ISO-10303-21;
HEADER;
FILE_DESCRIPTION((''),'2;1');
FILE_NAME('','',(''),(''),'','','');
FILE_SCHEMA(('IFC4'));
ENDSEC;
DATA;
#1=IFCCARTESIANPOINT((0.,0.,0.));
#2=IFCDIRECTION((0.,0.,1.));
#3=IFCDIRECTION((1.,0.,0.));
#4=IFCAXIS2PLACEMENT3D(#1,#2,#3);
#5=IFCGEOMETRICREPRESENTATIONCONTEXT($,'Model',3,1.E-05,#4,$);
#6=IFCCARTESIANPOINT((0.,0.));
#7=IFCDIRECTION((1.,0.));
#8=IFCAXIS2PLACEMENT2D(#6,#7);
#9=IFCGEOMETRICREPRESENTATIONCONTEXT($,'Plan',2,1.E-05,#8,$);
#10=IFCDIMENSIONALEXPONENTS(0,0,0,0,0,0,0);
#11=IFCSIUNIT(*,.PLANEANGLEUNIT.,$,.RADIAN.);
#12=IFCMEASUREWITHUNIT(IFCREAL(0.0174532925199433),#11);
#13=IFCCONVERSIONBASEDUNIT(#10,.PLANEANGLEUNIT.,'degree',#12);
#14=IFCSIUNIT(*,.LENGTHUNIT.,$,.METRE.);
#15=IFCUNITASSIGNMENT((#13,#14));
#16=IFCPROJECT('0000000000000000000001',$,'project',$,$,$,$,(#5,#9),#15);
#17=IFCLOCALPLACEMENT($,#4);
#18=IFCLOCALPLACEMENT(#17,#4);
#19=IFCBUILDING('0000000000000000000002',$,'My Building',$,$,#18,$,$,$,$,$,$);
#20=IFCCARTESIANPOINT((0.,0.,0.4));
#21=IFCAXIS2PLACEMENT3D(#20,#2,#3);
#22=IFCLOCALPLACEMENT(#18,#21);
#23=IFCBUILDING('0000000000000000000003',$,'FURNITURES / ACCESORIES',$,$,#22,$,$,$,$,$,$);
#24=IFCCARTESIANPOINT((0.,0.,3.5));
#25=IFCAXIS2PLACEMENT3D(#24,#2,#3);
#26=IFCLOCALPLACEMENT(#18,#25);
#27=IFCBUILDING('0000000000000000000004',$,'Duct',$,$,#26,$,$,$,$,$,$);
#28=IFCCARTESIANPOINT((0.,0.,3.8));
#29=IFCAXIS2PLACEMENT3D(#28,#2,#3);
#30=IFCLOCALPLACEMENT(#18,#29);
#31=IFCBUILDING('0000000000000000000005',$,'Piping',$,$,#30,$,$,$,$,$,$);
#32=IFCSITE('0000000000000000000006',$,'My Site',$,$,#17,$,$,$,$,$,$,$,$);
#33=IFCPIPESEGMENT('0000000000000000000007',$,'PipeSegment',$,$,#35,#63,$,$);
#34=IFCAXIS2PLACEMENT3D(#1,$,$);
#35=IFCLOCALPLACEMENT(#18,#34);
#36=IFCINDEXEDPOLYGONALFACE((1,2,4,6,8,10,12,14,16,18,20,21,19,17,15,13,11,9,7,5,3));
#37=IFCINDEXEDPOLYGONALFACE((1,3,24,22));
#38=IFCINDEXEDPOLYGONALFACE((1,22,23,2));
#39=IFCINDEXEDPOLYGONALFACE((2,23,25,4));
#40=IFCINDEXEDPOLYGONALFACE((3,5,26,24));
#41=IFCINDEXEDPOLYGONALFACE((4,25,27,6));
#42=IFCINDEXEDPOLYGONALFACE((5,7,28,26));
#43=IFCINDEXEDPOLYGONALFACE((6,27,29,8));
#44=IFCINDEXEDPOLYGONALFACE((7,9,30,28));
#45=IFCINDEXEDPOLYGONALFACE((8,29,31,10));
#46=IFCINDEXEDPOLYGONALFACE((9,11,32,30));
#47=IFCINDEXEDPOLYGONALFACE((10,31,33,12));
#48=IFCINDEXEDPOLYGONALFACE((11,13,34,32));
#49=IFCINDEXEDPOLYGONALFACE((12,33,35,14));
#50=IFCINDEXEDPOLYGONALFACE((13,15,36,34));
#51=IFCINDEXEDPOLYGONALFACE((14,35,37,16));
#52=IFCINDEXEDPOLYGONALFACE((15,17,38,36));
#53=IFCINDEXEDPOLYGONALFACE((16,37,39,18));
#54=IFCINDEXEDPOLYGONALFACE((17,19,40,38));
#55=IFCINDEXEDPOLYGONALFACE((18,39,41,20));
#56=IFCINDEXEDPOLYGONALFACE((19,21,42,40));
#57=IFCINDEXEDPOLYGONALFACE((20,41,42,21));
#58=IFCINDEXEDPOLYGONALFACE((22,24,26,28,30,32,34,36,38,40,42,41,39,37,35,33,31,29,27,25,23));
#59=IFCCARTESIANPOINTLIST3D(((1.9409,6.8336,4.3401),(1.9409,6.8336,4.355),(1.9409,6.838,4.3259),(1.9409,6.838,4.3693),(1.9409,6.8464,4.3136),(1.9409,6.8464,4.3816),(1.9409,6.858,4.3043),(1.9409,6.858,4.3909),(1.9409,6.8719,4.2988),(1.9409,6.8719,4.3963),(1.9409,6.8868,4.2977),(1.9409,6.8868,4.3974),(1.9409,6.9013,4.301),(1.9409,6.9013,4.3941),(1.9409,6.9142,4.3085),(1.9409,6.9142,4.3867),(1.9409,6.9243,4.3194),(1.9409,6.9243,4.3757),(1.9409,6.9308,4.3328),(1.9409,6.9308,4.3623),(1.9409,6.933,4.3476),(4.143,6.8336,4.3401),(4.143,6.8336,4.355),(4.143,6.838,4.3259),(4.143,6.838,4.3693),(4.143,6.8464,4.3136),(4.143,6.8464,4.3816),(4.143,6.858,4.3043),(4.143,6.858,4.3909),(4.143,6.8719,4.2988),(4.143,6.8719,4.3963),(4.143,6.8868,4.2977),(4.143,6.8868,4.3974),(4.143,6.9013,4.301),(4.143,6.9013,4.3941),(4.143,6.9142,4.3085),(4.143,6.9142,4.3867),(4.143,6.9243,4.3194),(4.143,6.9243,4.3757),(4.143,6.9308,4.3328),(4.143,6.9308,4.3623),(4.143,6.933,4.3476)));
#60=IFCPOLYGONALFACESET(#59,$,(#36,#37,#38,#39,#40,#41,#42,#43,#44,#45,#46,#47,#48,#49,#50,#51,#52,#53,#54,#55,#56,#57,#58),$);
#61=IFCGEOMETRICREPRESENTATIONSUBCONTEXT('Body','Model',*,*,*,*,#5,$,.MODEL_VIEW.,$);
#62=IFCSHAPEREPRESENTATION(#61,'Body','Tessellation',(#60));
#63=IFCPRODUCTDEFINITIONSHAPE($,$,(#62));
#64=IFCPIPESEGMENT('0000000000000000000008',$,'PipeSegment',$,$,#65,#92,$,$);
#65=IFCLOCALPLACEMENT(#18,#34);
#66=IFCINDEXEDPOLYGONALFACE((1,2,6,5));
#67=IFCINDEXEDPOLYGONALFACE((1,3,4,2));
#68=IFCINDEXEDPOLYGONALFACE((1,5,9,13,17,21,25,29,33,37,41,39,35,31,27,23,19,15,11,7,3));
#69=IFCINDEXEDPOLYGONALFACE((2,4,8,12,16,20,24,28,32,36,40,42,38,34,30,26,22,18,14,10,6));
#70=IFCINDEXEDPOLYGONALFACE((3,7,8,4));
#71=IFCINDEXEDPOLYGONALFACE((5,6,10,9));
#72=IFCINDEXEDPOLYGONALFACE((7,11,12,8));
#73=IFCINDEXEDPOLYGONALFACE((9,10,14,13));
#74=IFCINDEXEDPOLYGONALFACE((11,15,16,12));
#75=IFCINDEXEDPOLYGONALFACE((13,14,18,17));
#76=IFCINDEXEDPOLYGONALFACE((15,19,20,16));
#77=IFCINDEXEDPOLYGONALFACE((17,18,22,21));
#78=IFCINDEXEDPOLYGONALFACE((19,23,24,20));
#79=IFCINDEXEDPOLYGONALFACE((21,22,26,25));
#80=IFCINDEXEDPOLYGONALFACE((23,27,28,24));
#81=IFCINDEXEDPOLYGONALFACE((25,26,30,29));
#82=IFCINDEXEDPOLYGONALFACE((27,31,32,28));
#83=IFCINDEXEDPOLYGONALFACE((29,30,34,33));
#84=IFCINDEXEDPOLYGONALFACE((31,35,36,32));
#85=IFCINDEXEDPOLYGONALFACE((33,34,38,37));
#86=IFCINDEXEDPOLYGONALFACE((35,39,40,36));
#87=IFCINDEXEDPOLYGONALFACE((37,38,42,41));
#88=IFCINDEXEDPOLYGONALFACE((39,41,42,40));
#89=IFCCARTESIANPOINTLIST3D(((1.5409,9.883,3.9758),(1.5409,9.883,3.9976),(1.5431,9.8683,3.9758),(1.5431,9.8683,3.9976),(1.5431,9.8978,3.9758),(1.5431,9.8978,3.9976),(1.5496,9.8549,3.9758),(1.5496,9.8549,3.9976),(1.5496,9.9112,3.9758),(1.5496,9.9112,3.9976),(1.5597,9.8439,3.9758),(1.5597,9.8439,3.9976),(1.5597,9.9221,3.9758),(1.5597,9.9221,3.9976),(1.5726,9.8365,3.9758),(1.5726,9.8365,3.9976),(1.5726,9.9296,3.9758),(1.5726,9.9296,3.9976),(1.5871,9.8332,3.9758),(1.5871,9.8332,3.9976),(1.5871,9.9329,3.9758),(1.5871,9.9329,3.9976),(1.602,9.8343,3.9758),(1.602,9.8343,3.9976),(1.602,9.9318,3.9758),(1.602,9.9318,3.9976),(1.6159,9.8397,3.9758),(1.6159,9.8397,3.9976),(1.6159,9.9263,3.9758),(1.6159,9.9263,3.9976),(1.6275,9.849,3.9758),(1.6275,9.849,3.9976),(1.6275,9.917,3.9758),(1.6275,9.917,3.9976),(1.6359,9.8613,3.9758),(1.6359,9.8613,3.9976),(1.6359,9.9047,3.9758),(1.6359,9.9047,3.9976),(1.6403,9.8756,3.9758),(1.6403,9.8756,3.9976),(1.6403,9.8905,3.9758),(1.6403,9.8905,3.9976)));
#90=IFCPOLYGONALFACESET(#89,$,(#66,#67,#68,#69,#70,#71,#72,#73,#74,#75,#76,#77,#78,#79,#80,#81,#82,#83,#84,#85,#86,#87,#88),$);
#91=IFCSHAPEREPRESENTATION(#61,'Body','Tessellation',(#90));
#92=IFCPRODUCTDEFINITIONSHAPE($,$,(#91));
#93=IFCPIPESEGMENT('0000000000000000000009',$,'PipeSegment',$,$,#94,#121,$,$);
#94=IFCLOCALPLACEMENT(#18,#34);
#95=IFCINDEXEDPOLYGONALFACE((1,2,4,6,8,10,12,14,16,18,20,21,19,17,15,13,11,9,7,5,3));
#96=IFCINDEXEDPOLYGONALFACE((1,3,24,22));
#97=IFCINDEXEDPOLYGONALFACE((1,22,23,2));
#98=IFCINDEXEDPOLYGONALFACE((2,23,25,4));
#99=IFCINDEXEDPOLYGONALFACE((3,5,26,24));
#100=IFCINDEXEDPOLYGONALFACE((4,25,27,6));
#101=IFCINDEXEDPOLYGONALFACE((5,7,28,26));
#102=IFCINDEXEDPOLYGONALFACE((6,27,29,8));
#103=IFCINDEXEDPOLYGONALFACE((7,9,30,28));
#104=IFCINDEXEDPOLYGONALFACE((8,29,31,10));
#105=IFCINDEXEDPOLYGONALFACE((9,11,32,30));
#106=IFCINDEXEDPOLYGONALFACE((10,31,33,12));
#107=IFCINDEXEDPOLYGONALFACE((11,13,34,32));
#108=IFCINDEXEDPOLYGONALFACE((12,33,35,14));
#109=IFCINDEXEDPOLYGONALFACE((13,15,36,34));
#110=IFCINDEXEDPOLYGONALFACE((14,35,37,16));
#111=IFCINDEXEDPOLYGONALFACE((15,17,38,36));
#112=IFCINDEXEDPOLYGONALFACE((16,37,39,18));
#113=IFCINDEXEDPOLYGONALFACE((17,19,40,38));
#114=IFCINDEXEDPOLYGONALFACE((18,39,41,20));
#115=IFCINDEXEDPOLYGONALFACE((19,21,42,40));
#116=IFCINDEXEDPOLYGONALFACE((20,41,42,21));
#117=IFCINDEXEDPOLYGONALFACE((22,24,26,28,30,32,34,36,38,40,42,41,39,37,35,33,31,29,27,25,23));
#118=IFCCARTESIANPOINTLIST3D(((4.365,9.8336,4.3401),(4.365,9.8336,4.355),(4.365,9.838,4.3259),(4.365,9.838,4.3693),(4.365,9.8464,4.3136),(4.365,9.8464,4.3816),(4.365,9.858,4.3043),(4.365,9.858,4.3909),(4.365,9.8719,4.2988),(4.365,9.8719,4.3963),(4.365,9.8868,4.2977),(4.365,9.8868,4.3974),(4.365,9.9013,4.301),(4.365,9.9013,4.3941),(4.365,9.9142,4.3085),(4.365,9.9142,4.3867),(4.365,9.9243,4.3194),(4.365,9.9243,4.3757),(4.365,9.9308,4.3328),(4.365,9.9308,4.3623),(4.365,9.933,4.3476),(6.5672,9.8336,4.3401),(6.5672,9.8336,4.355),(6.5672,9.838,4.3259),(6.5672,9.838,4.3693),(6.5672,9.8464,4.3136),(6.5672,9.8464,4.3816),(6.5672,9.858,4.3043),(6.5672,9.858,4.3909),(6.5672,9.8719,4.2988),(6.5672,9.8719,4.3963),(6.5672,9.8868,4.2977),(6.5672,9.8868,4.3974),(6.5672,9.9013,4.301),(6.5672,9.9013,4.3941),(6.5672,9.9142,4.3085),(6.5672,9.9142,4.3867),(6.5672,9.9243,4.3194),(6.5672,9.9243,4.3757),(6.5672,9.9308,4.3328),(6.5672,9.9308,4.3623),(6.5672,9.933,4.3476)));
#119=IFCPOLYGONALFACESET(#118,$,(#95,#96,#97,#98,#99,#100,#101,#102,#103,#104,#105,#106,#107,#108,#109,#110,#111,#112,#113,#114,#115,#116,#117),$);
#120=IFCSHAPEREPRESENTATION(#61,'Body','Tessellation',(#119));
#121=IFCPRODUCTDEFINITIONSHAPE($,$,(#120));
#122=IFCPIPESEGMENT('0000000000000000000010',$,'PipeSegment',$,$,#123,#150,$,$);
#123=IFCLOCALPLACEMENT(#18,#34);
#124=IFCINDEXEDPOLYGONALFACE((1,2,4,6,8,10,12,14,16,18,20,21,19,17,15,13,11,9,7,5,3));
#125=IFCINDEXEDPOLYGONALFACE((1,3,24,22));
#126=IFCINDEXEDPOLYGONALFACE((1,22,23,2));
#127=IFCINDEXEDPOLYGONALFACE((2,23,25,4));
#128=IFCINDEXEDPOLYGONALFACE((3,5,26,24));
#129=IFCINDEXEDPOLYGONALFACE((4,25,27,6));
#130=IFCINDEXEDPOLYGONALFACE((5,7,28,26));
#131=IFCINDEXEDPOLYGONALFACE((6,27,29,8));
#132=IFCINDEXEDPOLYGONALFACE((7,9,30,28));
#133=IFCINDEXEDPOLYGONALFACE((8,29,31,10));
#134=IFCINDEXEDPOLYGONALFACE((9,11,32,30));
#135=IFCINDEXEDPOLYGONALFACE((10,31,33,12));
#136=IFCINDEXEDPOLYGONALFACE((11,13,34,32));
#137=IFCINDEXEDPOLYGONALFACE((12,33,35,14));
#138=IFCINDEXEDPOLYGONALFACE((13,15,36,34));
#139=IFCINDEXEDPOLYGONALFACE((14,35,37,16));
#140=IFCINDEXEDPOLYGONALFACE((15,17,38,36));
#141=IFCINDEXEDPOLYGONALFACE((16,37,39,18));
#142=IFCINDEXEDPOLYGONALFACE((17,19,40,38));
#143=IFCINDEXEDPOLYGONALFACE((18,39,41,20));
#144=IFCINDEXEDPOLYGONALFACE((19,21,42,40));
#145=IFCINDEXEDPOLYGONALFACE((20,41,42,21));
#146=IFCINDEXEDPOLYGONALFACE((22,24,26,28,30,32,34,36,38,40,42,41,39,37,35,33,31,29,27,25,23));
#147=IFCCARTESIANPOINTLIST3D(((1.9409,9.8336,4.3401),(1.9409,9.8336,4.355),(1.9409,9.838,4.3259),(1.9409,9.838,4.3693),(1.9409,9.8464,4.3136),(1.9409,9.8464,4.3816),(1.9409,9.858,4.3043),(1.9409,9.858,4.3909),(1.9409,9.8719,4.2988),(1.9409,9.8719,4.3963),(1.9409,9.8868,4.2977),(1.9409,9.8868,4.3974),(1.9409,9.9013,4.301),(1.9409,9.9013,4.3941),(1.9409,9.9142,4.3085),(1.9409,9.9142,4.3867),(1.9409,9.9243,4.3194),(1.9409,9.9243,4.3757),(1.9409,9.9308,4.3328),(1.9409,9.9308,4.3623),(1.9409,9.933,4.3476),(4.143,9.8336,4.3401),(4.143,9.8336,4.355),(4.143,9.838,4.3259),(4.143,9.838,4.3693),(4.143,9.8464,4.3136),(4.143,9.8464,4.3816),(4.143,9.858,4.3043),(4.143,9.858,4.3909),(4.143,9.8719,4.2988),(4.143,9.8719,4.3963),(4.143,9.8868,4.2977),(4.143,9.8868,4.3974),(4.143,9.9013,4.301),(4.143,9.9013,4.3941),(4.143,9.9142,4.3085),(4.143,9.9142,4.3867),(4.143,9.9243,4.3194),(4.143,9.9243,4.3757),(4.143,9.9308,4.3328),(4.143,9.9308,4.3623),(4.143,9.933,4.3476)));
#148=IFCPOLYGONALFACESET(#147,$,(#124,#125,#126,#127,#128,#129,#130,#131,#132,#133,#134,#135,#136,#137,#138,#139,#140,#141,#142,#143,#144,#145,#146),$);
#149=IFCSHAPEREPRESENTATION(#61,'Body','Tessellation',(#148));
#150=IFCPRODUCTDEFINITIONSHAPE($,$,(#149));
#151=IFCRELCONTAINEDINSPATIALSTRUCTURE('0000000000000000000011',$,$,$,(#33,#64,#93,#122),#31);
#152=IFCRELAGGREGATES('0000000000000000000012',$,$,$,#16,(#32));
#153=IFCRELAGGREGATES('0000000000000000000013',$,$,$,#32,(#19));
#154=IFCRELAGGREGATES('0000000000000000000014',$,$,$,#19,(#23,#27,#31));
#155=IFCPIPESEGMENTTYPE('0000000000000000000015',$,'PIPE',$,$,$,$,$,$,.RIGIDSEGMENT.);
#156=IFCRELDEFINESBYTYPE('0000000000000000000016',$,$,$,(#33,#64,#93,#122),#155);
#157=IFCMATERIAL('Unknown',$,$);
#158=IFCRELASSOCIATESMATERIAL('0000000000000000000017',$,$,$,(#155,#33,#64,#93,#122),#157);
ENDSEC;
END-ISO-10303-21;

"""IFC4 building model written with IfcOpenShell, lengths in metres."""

from ifc_helpers import new_model, entity, si_unit, converted_unit, frame, origin_with_axes, origin_2d_with_axis, place, context, subcontext, project, spatial, circle, extrude, material, material_profile, profile_set, profile_usage, type_object, element, save


model = new_model("IFC4")

# Units and contexts
model_context = context("Model", 3, precision=1e-05, world=origin_with_axes())
plan_context = context("Plan", 2, precision=1e-05, world=origin_2d_with_axis())
body_context = subcontext(model_context, "Body", "Model", "MODEL_VIEW")
ifc_project = project(units=[converted_unit("PLANEANGLEUNIT", "degree", entity("IfcReal", 0.0174532925199433), si_unit("PLANEANGLEUNIT", "RADIAN"), dimensions=[0, 0, 0, 0, 0, 0, 0]), si_unit("LENGTHUNIT", "METRE")], contexts=[model_context, plan_context])

# Site, building
site_placement = place(None, origin_with_axes())
site = spatial("IfcSite", under=ifc_project, at=site_placement, Name="My Site")
building_1_placement = place(site_placement, origin_with_axes())
building_1 = spatial("IfcBuilding", under=site, at=building_1_placement, Name="My Building")

# Shared definitions
ifc_material = material(Name="Unknown")

# Shared definitions
building_2_placement = place(building_1_placement, frame((0.0, 0.0, 0.4), z_axis=(0.0, 0.0, 1.0), x_axis=(1.0, 0.0, 0.0)))
building_2 = spatial("IfcBuilding", under=building_1, at=building_2_placement, Name="FURNITURES / ACCESORIES")

# Shared definitions
building_3_placement = place(building_1_placement, frame((0.0, 0.0, 3.5), z_axis=(0.0, 0.0, 1.0), x_axis=(1.0, 0.0, 0.0)))
building_3 = spatial("IfcBuilding", under=building_1, at=building_3_placement, Name="Duct")

# Shared definitions
building_4_placement = place(building_1_placement, frame((0.0, 0.0, 3.8), z_axis=(0.0, 0.0, 1.0), x_axis=(1.0, 0.0, 0.0)))
building_4 = spatial("IfcBuilding", under=building_1, at=building_4_placement, Name="Piping")

# Pipe segments
ifc_material_profile_1 = material_profile(ifc_material, circle(Radius=0.05))
ifc_profile_set_1 = profile_set([ifc_material_profile_1])
pipe_segment_type = type_object("IfcPipeSegmentType", Name="PIPE", PredefinedType="RIGIDSEGMENT", material=ifc_profile_set_1)
ifc_profile_usage_1 = profile_usage(ifc_profile_set_1, cardinal=5)
pipe_segment_1_placement = place(building_4_placement, frame((4.143, 6.883, 0.5476), z_axis=(-1.0, -0.000001, -0.000001), x_axis=(-0.000001, 1.0, 0.0)))
element("IfcPipeSegment", 1, at=pipe_segment_1_placement, inside=building_4, type_object=pipe_segment_type, material=ifc_profile_usage_1, Name="PipeSegment", context=body_context, shape_type="SweptSolid", body=[
    extrude(circle(Radius=0.05), origin_with_axes(), (0.0, 0.0, 1.0), 2.2022),
])
ifc_profile_usage_2 = profile_usage(ifc_profile_set_1, cardinal=5)
pipe_segment_2_placement = place(building_4_placement, frame((1.5909, 9.883, 0.1976), z_axis=(0.0, 0.0, -1.0), x_axis=(-1.0, 0.0, 0.0)))
element("IfcPipeSegment", 2, at=pipe_segment_2_placement, inside=building_4, type_object=pipe_segment_type, material=ifc_profile_usage_2, Name="PipeSegment", context=body_context, shape_type="SweptSolid", body=[
    extrude(circle(Radius=0.05), origin_with_axes(), (0.0, 0.0, 1.0), 0.0218),
])
ifc_profile_usage_3 = profile_usage(ifc_profile_set_1, cardinal=5)
pipe_segment_3_placement = place(building_4_placement, frame((4.365, 9.883, 0.5476), z_axis=(1.0, -0.000001, 0.000001), x_axis=(0.000001, 1.0, 0.0)))
element("IfcPipeSegment", 3, at=pipe_segment_3_placement, inside=building_4, type_object=pipe_segment_type, material=ifc_profile_usage_3, Name="PipeSegment", context=body_context, shape_type="SweptSolid", body=[
    extrude(circle(Radius=0.05), origin_with_axes(), (0.0, 0.0, 1.0), 2.2022),
])
ifc_profile_usage_4 = profile_usage(ifc_profile_set_1, cardinal=5)
pipe_segment_4_placement = place(building_4_placement, frame((4.143, 9.883, 0.5476), z_axis=(-1.0, -0.000001, -0.000001), x_axis=(-0.000001, 1.0, 0.0)))
element("IfcPipeSegment", 4, at=pipe_segment_4_placement, inside=building_4, type_object=pipe_segment_type, material=ifc_profile_usage_4, Name="PipeSegment", context=body_context, shape_type="SweptSolid", body=[
    extrude(circle(Radius=0.05), origin_with_axes(), (0.0, 0.0, 1.0), 2.2022),
])

save(model, "model.ifc")
